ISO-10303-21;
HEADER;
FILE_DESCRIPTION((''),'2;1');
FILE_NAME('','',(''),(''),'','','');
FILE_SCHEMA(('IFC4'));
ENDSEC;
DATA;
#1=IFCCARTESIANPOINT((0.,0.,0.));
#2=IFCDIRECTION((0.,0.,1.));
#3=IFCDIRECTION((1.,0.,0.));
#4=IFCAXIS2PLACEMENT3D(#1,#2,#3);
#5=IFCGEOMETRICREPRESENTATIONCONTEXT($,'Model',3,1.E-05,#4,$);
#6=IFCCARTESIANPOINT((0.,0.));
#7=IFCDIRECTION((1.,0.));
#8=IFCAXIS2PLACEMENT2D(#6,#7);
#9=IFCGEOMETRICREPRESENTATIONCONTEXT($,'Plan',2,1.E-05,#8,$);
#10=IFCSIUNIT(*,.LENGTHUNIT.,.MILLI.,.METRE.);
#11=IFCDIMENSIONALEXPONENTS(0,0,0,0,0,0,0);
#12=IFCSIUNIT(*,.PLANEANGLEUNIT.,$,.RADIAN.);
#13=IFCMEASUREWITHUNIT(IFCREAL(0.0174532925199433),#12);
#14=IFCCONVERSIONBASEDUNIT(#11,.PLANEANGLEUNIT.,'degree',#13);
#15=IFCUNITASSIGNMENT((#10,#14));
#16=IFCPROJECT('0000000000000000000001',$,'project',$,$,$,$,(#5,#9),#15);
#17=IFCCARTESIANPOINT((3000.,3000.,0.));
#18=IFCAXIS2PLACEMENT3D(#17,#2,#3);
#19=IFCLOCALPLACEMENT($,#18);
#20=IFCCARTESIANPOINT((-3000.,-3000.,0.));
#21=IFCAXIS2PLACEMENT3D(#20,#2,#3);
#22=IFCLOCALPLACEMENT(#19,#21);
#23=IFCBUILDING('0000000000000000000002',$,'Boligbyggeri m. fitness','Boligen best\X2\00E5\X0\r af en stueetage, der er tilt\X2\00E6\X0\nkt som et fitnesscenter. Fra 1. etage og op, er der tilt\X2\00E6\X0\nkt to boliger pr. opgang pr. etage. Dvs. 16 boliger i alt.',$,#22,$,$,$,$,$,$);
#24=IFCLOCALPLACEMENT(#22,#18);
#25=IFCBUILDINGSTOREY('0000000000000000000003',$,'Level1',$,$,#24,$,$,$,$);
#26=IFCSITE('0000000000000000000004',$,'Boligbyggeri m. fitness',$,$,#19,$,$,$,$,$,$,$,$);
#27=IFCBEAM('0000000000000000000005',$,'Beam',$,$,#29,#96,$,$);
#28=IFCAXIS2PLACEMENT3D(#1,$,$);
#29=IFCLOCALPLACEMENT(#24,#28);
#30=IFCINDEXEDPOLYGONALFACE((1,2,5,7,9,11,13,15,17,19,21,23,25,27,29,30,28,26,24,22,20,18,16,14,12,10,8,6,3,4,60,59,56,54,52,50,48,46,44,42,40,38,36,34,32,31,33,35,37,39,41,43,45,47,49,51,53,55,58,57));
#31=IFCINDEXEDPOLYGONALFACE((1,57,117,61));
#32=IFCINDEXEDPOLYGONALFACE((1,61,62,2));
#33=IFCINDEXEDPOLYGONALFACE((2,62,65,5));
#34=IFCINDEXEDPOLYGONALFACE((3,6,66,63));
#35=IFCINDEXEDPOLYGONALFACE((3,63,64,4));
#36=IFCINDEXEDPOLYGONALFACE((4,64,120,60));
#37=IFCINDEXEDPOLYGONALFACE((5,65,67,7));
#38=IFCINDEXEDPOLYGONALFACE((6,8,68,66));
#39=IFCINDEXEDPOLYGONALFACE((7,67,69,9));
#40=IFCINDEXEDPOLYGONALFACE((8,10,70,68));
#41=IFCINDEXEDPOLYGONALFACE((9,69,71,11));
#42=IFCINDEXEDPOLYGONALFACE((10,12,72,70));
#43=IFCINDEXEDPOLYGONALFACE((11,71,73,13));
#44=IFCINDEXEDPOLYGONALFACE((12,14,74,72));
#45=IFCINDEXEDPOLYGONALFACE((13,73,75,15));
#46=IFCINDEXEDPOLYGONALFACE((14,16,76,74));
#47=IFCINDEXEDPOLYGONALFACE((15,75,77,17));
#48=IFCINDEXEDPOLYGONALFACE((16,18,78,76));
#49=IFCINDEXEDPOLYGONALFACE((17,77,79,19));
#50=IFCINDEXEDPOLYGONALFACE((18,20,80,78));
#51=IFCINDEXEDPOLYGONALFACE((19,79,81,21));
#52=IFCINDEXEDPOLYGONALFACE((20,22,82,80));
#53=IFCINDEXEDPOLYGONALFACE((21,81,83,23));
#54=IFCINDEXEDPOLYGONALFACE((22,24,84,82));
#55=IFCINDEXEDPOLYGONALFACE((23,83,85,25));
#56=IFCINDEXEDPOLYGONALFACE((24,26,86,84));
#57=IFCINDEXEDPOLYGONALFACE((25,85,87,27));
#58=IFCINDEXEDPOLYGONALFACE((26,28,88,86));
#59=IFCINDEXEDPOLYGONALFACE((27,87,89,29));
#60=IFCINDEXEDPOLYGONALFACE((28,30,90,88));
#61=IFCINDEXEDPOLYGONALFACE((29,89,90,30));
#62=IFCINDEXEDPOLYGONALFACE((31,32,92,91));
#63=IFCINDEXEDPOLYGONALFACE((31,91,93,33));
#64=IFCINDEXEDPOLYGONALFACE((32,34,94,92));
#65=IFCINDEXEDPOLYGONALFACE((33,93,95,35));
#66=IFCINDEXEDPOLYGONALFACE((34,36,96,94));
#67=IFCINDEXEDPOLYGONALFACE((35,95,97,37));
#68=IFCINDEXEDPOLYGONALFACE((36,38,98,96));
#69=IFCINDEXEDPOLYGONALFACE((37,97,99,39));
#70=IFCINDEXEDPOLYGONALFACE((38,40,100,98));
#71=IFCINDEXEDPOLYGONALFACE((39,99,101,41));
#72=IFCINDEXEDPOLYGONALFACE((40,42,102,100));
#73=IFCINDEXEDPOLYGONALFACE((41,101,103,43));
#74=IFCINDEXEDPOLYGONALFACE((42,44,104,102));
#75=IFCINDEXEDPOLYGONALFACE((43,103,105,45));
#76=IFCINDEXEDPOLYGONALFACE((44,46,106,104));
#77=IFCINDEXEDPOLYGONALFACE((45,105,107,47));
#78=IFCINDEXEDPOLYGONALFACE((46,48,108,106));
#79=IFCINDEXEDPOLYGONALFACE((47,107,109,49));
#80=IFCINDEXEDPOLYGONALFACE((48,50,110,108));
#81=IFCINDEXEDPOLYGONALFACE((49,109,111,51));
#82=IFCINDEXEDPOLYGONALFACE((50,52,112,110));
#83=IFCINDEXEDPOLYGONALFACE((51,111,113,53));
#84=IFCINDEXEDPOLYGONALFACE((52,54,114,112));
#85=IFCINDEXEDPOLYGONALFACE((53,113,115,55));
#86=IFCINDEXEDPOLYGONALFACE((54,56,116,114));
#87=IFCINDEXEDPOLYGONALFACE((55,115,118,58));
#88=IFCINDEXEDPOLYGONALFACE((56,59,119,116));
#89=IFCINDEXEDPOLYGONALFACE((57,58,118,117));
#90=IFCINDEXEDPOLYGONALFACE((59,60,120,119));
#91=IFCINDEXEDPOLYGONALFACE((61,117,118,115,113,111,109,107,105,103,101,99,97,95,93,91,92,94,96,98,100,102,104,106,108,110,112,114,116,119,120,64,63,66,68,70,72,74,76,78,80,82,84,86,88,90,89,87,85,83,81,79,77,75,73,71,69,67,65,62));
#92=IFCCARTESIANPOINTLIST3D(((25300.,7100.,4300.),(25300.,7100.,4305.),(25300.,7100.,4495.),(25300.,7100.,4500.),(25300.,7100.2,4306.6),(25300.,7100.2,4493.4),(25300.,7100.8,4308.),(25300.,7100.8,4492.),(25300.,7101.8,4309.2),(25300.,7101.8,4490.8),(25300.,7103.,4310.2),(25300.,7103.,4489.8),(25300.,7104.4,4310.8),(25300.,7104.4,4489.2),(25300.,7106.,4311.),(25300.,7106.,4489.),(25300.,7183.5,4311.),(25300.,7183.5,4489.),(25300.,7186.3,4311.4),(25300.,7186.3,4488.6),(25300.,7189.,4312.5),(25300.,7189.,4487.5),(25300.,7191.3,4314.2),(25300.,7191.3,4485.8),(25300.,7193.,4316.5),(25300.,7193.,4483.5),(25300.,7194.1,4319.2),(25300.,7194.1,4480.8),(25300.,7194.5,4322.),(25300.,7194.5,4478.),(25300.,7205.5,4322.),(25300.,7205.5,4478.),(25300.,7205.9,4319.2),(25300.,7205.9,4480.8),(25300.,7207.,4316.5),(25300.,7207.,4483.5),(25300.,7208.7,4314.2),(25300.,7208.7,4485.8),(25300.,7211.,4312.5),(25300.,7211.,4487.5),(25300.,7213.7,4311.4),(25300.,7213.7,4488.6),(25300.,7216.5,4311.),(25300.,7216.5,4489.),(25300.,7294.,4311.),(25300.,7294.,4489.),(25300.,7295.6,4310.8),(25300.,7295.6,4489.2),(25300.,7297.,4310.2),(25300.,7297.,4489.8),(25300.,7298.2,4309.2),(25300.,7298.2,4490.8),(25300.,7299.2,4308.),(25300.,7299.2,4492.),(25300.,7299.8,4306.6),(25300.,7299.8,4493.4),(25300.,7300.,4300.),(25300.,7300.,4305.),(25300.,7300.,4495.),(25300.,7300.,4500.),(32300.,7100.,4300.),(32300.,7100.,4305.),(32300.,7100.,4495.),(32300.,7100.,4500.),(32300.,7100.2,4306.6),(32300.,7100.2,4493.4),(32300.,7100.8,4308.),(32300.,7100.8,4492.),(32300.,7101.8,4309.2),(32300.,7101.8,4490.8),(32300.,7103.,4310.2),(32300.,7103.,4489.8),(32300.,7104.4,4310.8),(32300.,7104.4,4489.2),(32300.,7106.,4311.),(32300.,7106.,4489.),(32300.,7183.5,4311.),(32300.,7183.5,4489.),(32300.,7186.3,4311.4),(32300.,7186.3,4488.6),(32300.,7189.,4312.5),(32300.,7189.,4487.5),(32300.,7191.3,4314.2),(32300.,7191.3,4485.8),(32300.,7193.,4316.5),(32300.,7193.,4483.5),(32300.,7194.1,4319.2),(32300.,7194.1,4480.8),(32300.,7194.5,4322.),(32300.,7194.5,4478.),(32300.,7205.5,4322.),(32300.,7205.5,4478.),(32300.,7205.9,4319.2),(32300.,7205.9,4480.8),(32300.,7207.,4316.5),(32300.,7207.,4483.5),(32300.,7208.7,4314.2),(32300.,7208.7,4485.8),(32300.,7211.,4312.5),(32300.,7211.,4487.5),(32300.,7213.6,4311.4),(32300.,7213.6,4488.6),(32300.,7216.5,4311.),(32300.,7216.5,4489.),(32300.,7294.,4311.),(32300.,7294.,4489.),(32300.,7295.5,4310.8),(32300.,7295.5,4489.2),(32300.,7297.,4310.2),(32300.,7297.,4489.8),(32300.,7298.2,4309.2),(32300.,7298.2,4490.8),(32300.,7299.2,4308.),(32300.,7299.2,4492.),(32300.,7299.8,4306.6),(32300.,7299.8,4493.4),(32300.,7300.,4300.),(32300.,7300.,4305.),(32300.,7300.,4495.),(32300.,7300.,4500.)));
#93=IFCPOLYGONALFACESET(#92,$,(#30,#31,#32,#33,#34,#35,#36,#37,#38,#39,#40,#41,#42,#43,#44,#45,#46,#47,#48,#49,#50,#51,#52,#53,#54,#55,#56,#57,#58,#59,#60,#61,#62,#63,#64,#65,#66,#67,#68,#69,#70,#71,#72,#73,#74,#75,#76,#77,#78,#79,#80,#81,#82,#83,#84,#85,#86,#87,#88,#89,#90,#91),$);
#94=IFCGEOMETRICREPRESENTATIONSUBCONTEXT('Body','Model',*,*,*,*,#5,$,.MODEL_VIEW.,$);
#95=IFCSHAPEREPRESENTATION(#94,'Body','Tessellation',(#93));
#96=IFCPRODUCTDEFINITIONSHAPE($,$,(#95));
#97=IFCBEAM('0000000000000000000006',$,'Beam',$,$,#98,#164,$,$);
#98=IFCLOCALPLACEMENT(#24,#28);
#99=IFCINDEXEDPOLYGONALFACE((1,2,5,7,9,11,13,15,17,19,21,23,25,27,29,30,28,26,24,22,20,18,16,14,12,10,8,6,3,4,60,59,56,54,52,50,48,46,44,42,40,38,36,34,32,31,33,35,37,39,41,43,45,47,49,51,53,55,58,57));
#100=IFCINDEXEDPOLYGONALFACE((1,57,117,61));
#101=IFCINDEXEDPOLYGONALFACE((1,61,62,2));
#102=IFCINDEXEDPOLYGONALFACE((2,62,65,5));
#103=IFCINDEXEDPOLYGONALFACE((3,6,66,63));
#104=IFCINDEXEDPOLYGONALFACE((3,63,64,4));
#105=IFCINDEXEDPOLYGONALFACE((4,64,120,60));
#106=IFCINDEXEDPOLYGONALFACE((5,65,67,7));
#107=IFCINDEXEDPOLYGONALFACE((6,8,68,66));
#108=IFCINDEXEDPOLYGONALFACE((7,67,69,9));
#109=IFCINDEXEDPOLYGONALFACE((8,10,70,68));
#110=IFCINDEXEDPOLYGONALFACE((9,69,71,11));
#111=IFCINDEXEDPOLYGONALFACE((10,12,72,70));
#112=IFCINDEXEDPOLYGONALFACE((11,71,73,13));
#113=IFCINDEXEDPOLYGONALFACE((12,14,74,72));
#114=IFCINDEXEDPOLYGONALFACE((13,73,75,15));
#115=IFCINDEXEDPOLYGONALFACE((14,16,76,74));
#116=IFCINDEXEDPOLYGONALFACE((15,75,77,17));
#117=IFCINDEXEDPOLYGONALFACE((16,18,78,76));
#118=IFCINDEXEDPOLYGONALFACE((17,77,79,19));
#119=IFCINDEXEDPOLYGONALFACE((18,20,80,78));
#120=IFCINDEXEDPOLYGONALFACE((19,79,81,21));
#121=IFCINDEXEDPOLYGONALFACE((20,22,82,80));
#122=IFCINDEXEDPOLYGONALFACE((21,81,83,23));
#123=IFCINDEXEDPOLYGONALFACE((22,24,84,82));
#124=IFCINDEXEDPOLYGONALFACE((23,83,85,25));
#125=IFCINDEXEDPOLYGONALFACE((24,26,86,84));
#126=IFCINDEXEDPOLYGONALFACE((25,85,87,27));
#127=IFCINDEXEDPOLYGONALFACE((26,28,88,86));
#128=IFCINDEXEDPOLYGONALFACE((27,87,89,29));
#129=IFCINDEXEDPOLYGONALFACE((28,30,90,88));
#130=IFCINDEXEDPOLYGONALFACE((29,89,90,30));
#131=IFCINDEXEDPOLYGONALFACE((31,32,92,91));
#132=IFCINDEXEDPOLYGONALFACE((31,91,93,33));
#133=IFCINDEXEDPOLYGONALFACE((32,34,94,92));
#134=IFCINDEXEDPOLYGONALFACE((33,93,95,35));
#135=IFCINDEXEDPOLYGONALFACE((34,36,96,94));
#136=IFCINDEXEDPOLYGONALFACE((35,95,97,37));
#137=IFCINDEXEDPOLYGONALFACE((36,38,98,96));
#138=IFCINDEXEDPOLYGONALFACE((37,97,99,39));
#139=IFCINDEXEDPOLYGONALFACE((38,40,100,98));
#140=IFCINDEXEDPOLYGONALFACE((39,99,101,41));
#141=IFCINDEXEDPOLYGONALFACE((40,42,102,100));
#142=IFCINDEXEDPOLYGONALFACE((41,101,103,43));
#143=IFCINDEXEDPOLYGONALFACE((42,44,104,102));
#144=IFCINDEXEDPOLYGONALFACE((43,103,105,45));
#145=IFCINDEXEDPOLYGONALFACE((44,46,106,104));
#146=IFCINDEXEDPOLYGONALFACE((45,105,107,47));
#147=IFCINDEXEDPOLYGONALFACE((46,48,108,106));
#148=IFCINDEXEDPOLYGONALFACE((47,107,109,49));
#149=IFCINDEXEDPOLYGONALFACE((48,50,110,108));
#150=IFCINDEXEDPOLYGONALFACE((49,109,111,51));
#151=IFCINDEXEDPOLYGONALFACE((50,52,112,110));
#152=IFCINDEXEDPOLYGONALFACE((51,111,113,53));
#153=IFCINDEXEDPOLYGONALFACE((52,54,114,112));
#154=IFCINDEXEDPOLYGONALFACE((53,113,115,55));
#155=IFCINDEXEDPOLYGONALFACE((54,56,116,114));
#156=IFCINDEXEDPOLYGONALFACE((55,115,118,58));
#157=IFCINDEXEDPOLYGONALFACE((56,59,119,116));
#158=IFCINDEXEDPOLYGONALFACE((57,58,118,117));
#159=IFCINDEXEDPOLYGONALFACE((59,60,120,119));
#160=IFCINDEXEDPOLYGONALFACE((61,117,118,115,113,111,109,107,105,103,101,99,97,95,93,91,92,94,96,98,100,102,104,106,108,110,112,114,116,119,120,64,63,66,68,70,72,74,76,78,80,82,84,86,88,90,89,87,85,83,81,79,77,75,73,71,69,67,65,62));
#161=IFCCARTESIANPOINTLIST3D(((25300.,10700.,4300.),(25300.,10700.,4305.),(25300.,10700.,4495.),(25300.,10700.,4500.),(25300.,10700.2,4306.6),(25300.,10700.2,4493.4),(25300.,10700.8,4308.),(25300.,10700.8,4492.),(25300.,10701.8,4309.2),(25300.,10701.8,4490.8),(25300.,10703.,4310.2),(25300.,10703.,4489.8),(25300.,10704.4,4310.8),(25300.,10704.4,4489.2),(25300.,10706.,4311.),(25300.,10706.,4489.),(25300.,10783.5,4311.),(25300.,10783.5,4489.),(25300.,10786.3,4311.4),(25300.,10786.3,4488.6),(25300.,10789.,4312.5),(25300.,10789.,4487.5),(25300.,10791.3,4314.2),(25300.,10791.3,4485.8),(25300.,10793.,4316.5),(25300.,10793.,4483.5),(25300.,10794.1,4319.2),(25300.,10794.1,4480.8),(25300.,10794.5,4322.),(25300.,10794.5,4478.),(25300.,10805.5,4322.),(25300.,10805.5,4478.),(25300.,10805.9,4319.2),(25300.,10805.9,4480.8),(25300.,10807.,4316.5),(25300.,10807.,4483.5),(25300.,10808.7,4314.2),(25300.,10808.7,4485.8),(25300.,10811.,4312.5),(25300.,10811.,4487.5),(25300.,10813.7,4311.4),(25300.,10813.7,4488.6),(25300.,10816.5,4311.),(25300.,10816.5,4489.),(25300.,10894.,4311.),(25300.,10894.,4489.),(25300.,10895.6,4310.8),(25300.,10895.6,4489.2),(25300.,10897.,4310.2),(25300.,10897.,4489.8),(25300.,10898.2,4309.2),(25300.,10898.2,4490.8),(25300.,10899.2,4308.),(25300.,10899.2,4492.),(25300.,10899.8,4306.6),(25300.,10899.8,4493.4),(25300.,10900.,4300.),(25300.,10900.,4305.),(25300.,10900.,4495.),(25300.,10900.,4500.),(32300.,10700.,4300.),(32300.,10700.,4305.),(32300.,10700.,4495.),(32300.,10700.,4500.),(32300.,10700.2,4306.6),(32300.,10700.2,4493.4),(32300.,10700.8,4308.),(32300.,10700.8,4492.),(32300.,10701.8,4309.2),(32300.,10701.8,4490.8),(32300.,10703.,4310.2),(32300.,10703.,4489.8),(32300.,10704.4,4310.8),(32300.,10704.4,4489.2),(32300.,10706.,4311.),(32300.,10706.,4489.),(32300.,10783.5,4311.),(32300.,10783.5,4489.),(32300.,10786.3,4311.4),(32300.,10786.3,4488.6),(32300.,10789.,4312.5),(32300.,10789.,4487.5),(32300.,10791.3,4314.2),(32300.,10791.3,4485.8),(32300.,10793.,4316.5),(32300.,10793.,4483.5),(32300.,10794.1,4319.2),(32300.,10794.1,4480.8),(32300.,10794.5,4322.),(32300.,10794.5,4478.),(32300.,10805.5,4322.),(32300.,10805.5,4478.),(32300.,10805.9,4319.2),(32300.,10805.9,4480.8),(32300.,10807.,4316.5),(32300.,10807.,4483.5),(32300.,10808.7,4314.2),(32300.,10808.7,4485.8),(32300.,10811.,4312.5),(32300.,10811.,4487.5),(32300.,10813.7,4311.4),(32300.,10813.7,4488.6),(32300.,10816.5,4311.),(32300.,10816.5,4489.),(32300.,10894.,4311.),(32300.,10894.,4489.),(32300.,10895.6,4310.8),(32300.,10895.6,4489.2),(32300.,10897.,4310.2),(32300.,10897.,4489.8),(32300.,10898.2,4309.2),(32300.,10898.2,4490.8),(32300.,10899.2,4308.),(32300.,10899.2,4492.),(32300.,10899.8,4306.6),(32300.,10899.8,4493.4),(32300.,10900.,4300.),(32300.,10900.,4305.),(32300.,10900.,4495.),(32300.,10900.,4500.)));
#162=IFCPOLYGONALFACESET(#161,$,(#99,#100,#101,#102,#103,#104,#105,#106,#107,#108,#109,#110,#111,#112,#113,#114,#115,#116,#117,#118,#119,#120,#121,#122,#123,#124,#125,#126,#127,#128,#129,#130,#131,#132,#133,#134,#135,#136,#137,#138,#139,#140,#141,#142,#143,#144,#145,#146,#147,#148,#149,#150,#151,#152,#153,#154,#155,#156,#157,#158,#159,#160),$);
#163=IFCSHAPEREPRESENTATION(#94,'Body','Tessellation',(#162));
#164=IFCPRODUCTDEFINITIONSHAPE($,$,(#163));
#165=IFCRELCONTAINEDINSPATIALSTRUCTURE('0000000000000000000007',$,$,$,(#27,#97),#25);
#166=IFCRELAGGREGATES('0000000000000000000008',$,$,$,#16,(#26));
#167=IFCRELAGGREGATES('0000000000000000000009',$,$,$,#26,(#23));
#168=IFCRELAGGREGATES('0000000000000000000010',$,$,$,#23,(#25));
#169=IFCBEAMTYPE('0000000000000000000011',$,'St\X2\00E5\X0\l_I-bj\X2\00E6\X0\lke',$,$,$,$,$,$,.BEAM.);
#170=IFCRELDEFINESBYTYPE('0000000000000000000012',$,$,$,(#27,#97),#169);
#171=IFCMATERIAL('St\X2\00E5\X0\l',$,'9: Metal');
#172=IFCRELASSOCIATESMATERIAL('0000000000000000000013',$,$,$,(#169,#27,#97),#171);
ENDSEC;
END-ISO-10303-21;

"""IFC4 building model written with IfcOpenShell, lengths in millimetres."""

from ifc_helpers import new_model, entity, si_unit, converted_unit, frame, origin_with_axes, origin_2d_with_axis, place, context, subcontext, project, spatial, i_section, extrude, material, material_profile, profile_set, profile_usage, type_object, element, save


model = new_model("IFC4")

# Units and contexts
model_context = context("Model", 3, precision=1e-05, world=origin_with_axes())
plan_context = context("Plan", 2, precision=1e-05, world=origin_2d_with_axis())
body_context = subcontext(model_context, "Body", "Model", "MODEL_VIEW")
ifc_project = project(units=[si_unit("LENGTHUNIT", "METRE", prefix="MILLI"), converted_unit("PLANEANGLEUNIT", "degree", entity("IfcReal", 0.0174532925199433), si_unit("PLANEANGLEUNIT", "RADIAN"), dimensions=[0, 0, 0, 0, 0, 0, 0])], contexts=[model_context, plan_context])

# Site, building, storey
site_placement = place(None, frame((3000.0, 3000.0, 0.0), z_axis=(0.0, 0.0, 1.0), x_axis=(1.0, 0.0, 0.0)))
site = spatial("IfcSite", under=ifc_project, at=site_placement, Name="Boligbyggeri m. fitness")
building_placement = place(site_placement, frame((-3000.0, -3000.0, 0.0), z_axis=(0.0, 0.0, 1.0), x_axis=(1.0, 0.0, 0.0)))
building = spatial("IfcBuilding", under=site, at=building_placement, Name="Boligbyggeri m. fitness", Description="Boligen består af en stueetage, der er tiltænkt som et fitnesscenter. Fra 1. etage og op, er der tiltænkt to boliger pr. opgang pr. etage. Dvs. 16 boliger i alt.")
storey_placement = place(building_placement, frame((3000.0, 3000.0, 0.0), z_axis=(0.0, 0.0, 1.0), x_axis=(1.0, 0.0, 0.0)))
storey = spatial("IfcBuildingStorey", under=building, at=storey_placement, Name="Level1")

# Beams
ifc_material_1 = material(Name="Stål", Category="9: Metal")
ifc_material_profile_1 = material_profile(ifc_material_1, i_section(OverallWidth=200.0, OverallDepth=200.0, WebThickness=11.0, FlangeThickness=11.0, FilletRadius=11.0, FlangeEdgeRadius=6.0), Name="Stål", Category="9: Metal")
ifc_profile_set_1 = profile_set([ifc_material_profile_1], Name="NY_I-Profil")
beam_type = type_object("IfcBeamType", Name="Stål_I-bjælke", PredefinedType="BEAM", material=ifc_profile_set_1)
ifc_profile_usage_1 = profile_usage(ifc_profile_set_1, cardinal=7)
beam_1_placement = place(storey_placement, frame((25300.0, 7300.0, 4500.0), z_axis=(1.0, 0.0, 0.0), x_axis=(0.0, 1.0, 0.0)))
element("IfcBeam", 1, at=beam_1_placement, inside=storey, type_object=beam_type, material=ifc_profile_usage_1, Name="Beam", context=body_context, shape_type="SweptSolid", body=[
    extrude(i_section(OverallWidth=200.0, OverallDepth=200.0, WebThickness=11.0, FlangeThickness=11.0, FilletRadius=11.0, FlangeEdgeRadius=6.0), frame((-100.0, -100.0, 0.0), z_axis=(0.0, 0.0, 1.0), x_axis=(1.0, 0.0, 0.0)), (0.0, 0.0, 1.0), 7000.0),
])
ifc_profile_usage_2 = profile_usage(ifc_profile_set_1, cardinal=7)
beam_2_placement = place(storey_placement, frame((25300.0, 10900.0, 4500.0), z_axis=(1.0, 0.0, 0.0), x_axis=(0.0, 1.0, 0.0)))
element("IfcBeam", 2, at=beam_2_placement, inside=storey, type_object=beam_type, material=ifc_profile_usage_2, Name="Beam", context=body_context, shape_type="SweptSolid", body=[
    extrude(i_section(OverallWidth=200.0, OverallDepth=200.0, WebThickness=11.0, FlangeThickness=11.0, FilletRadius=11.0, FlangeEdgeRadius=6.0), frame((-100.0, -100.0, 0.0), z_axis=(0.0, 0.0, 1.0), x_axis=(1.0, 0.0, 0.0)), (0.0, 0.0, 1.0), 7000.0),
])

save(model, "model.ifc")
